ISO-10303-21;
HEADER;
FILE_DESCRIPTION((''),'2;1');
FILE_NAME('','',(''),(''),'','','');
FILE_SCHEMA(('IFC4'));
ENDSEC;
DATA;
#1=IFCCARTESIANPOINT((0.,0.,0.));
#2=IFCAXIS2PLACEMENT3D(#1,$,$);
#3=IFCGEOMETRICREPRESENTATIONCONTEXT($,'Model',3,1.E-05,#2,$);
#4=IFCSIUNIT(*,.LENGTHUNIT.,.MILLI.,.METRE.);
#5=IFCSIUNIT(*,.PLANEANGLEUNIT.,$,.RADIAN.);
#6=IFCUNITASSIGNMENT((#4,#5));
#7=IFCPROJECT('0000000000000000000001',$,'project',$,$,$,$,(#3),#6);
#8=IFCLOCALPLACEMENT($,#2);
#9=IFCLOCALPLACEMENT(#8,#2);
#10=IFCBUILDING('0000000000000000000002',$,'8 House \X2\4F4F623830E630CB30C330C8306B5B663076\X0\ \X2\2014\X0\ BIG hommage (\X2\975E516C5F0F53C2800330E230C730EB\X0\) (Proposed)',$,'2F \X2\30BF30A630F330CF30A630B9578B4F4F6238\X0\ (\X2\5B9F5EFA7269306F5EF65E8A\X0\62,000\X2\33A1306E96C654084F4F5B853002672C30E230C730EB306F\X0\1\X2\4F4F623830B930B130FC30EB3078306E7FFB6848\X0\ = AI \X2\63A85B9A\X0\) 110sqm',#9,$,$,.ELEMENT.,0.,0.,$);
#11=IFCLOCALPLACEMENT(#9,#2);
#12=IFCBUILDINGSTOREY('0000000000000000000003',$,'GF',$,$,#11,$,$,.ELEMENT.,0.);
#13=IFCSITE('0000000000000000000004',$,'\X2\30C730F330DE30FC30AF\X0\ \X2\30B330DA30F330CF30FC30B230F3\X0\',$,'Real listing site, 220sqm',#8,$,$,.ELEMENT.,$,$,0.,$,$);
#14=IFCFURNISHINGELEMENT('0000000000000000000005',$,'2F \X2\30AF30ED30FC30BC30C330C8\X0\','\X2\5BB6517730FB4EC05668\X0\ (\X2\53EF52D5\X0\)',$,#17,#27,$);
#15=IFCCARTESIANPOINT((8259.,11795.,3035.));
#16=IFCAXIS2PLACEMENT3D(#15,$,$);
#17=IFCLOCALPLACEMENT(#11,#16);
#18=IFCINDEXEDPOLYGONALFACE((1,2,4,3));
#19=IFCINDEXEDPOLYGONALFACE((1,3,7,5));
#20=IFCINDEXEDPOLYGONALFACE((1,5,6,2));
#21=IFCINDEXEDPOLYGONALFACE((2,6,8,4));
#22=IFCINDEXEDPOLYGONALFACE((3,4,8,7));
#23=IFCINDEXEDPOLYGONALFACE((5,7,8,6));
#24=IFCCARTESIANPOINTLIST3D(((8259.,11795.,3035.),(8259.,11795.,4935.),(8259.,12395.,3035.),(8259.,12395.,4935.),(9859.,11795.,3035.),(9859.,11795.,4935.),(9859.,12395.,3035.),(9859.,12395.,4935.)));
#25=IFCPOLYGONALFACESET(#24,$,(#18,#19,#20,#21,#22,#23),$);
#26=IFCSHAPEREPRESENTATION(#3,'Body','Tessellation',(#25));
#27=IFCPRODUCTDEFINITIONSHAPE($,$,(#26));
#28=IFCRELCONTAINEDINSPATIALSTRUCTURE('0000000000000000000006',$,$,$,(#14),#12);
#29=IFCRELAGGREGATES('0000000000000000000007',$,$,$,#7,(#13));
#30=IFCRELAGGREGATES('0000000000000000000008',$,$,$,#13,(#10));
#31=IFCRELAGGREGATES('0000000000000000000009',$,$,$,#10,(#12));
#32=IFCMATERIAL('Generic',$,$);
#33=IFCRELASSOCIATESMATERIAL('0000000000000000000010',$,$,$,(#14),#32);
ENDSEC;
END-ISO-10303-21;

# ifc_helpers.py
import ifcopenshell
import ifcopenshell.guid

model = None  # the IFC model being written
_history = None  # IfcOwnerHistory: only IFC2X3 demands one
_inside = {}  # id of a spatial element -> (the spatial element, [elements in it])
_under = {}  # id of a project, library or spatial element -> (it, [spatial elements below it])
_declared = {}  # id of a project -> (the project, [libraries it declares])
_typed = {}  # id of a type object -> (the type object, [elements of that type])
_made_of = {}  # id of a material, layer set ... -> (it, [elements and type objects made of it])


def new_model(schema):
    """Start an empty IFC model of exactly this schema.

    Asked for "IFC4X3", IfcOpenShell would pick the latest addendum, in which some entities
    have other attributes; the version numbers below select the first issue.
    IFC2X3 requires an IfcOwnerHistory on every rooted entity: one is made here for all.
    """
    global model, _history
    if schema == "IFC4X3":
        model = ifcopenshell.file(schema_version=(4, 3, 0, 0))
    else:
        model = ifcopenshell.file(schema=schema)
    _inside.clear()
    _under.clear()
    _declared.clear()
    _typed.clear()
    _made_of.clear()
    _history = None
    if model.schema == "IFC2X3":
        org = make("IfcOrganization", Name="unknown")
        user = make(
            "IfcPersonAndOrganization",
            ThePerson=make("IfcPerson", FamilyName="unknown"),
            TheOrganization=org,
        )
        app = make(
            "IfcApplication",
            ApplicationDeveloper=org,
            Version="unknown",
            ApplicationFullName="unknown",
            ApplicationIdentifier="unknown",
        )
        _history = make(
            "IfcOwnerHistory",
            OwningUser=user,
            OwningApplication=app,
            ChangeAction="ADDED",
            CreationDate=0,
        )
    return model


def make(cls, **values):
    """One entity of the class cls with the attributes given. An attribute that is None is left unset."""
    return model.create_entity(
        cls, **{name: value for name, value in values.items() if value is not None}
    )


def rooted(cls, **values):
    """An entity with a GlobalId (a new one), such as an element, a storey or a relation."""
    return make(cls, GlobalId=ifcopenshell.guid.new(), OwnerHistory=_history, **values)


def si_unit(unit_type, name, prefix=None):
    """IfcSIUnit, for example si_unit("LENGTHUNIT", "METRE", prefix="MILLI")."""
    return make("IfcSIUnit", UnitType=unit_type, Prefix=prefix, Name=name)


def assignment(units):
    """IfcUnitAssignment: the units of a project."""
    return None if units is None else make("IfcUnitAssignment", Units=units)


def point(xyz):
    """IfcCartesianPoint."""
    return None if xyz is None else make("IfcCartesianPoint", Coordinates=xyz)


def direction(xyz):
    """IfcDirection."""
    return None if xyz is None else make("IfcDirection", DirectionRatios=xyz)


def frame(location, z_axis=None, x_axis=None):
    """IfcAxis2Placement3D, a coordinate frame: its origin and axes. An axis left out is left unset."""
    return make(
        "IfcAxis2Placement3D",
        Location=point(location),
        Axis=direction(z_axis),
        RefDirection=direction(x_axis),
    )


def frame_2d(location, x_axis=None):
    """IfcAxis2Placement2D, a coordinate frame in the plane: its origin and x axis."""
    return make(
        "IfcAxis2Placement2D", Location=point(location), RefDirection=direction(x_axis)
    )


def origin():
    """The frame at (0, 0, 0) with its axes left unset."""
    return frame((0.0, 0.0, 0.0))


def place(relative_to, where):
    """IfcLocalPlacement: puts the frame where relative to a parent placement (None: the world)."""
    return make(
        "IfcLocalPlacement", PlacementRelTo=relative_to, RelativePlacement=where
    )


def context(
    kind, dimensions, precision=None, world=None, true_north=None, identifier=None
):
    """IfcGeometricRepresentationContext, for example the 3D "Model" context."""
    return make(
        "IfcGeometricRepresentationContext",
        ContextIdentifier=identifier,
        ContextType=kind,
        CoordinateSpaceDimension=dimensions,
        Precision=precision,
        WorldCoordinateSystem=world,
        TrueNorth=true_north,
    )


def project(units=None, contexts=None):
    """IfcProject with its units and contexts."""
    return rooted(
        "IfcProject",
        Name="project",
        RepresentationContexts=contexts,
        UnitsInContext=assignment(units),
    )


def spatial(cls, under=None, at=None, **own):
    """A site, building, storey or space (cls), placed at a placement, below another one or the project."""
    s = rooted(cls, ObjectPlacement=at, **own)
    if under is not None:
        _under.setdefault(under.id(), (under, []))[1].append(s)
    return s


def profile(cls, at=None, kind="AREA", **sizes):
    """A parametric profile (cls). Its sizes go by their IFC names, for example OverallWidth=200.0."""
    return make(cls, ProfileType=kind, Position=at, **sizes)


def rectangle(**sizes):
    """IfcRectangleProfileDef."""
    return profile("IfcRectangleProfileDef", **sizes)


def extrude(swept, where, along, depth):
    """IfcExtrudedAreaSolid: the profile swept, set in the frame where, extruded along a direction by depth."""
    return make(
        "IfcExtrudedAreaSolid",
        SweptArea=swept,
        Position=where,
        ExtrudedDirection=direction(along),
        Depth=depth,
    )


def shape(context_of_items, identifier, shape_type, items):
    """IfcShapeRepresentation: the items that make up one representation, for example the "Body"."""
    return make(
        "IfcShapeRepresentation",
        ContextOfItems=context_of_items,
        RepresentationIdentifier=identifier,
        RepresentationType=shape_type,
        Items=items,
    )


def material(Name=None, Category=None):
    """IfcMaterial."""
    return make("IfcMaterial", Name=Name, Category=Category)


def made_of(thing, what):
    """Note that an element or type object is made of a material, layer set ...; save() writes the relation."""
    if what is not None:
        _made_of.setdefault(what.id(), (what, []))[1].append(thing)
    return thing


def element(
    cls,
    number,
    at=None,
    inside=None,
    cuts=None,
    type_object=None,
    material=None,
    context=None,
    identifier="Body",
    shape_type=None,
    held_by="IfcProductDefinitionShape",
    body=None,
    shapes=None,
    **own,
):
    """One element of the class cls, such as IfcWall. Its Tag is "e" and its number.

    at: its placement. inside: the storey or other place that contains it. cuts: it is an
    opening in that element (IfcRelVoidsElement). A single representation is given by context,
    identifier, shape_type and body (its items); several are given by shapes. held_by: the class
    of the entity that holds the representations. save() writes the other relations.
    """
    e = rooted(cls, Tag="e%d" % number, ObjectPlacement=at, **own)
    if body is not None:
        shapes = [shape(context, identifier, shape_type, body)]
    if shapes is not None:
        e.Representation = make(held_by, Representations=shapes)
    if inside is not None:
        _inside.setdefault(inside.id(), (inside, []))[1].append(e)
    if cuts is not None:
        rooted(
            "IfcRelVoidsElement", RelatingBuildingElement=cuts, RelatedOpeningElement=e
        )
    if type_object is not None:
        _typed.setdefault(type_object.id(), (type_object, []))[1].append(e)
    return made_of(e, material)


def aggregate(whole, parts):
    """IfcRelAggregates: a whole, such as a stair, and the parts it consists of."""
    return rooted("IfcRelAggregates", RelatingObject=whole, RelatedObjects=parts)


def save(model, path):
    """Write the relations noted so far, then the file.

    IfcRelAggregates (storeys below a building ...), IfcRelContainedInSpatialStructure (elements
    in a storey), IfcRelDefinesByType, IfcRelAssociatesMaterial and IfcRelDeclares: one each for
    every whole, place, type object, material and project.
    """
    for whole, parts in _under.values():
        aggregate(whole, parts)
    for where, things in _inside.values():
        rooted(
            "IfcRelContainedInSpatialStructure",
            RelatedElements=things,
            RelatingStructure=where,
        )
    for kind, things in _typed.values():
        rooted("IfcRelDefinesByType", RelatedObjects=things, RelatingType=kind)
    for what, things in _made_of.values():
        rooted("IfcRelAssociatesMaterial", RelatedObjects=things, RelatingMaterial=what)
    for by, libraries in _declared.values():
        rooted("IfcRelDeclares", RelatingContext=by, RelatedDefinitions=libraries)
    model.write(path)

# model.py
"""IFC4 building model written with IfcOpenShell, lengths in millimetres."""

from ifc_helpers import new_model, si_unit, frame, frame_2d, origin, place, context, project, spatial, rectangle, extrude, material, element, save


model = new_model("IFC4")

# Units and contexts
model_context = context("Model", 3, precision=1e-05, world=origin())
ifc_project = project(units=[si_unit("LENGTHUNIT", "METRE", prefix="MILLI"), si_unit("PLANEANGLEUNIT", "RADIAN")], contexts=[model_context])

# Site, building, storey
site_placement = place(None, origin())
site = spatial("IfcSite", under=ifc_project, at=site_placement, Name="デンマーク コペンハーゲン", ObjectType="Real listing site, 220sqm", CompositionType="ELEMENT", RefElevation=0.0)
building_placement = place(site_placement, origin())
building = spatial("IfcBuilding", under=site, at=building_placement, Name="8 House 住戸ユニットに学ぶ — BIG hommage (非公式参考モデル) (Proposed)", ObjectType="2F タウンハウス型住戸 (実建物は延床62,000㎡の集合住宅。本モデルは1住戸スケールへの翻案 = AI 推定) 110sqm", CompositionType="ELEMENT", ElevationOfRefHeight=0.0, ElevationOfTerrain=0.0)
storey_placement = place(building_placement, origin())
storey = spatial("IfcBuildingStorey", under=building, at=storey_placement, Name="GF", CompositionType="ELEMENT", Elevation=0.0)

# Shared definitions
ifc_material_1 = material(Name="Generic")

# Furnishing element
furnishing_1_placement = place(storey_placement, frame((8259.0, 11795.0, 3035.0)))
element("IfcFurnishingElement", 1, at=furnishing_1_placement, inside=storey, material=ifc_material_1, Name="2F クローゼット", Description="家具・什器 (可動)", context=model_context, shape_type="SweptSolid", body=[
    extrude(rectangle(XDim=1600.0, YDim=600.0, at=frame_2d((800.0, 300.0))), frame((8259.0, 11795.0, 3035.0)), (0.0, 0.0, 1.0), 1900.0),
])

save(model, "model.ifc")
